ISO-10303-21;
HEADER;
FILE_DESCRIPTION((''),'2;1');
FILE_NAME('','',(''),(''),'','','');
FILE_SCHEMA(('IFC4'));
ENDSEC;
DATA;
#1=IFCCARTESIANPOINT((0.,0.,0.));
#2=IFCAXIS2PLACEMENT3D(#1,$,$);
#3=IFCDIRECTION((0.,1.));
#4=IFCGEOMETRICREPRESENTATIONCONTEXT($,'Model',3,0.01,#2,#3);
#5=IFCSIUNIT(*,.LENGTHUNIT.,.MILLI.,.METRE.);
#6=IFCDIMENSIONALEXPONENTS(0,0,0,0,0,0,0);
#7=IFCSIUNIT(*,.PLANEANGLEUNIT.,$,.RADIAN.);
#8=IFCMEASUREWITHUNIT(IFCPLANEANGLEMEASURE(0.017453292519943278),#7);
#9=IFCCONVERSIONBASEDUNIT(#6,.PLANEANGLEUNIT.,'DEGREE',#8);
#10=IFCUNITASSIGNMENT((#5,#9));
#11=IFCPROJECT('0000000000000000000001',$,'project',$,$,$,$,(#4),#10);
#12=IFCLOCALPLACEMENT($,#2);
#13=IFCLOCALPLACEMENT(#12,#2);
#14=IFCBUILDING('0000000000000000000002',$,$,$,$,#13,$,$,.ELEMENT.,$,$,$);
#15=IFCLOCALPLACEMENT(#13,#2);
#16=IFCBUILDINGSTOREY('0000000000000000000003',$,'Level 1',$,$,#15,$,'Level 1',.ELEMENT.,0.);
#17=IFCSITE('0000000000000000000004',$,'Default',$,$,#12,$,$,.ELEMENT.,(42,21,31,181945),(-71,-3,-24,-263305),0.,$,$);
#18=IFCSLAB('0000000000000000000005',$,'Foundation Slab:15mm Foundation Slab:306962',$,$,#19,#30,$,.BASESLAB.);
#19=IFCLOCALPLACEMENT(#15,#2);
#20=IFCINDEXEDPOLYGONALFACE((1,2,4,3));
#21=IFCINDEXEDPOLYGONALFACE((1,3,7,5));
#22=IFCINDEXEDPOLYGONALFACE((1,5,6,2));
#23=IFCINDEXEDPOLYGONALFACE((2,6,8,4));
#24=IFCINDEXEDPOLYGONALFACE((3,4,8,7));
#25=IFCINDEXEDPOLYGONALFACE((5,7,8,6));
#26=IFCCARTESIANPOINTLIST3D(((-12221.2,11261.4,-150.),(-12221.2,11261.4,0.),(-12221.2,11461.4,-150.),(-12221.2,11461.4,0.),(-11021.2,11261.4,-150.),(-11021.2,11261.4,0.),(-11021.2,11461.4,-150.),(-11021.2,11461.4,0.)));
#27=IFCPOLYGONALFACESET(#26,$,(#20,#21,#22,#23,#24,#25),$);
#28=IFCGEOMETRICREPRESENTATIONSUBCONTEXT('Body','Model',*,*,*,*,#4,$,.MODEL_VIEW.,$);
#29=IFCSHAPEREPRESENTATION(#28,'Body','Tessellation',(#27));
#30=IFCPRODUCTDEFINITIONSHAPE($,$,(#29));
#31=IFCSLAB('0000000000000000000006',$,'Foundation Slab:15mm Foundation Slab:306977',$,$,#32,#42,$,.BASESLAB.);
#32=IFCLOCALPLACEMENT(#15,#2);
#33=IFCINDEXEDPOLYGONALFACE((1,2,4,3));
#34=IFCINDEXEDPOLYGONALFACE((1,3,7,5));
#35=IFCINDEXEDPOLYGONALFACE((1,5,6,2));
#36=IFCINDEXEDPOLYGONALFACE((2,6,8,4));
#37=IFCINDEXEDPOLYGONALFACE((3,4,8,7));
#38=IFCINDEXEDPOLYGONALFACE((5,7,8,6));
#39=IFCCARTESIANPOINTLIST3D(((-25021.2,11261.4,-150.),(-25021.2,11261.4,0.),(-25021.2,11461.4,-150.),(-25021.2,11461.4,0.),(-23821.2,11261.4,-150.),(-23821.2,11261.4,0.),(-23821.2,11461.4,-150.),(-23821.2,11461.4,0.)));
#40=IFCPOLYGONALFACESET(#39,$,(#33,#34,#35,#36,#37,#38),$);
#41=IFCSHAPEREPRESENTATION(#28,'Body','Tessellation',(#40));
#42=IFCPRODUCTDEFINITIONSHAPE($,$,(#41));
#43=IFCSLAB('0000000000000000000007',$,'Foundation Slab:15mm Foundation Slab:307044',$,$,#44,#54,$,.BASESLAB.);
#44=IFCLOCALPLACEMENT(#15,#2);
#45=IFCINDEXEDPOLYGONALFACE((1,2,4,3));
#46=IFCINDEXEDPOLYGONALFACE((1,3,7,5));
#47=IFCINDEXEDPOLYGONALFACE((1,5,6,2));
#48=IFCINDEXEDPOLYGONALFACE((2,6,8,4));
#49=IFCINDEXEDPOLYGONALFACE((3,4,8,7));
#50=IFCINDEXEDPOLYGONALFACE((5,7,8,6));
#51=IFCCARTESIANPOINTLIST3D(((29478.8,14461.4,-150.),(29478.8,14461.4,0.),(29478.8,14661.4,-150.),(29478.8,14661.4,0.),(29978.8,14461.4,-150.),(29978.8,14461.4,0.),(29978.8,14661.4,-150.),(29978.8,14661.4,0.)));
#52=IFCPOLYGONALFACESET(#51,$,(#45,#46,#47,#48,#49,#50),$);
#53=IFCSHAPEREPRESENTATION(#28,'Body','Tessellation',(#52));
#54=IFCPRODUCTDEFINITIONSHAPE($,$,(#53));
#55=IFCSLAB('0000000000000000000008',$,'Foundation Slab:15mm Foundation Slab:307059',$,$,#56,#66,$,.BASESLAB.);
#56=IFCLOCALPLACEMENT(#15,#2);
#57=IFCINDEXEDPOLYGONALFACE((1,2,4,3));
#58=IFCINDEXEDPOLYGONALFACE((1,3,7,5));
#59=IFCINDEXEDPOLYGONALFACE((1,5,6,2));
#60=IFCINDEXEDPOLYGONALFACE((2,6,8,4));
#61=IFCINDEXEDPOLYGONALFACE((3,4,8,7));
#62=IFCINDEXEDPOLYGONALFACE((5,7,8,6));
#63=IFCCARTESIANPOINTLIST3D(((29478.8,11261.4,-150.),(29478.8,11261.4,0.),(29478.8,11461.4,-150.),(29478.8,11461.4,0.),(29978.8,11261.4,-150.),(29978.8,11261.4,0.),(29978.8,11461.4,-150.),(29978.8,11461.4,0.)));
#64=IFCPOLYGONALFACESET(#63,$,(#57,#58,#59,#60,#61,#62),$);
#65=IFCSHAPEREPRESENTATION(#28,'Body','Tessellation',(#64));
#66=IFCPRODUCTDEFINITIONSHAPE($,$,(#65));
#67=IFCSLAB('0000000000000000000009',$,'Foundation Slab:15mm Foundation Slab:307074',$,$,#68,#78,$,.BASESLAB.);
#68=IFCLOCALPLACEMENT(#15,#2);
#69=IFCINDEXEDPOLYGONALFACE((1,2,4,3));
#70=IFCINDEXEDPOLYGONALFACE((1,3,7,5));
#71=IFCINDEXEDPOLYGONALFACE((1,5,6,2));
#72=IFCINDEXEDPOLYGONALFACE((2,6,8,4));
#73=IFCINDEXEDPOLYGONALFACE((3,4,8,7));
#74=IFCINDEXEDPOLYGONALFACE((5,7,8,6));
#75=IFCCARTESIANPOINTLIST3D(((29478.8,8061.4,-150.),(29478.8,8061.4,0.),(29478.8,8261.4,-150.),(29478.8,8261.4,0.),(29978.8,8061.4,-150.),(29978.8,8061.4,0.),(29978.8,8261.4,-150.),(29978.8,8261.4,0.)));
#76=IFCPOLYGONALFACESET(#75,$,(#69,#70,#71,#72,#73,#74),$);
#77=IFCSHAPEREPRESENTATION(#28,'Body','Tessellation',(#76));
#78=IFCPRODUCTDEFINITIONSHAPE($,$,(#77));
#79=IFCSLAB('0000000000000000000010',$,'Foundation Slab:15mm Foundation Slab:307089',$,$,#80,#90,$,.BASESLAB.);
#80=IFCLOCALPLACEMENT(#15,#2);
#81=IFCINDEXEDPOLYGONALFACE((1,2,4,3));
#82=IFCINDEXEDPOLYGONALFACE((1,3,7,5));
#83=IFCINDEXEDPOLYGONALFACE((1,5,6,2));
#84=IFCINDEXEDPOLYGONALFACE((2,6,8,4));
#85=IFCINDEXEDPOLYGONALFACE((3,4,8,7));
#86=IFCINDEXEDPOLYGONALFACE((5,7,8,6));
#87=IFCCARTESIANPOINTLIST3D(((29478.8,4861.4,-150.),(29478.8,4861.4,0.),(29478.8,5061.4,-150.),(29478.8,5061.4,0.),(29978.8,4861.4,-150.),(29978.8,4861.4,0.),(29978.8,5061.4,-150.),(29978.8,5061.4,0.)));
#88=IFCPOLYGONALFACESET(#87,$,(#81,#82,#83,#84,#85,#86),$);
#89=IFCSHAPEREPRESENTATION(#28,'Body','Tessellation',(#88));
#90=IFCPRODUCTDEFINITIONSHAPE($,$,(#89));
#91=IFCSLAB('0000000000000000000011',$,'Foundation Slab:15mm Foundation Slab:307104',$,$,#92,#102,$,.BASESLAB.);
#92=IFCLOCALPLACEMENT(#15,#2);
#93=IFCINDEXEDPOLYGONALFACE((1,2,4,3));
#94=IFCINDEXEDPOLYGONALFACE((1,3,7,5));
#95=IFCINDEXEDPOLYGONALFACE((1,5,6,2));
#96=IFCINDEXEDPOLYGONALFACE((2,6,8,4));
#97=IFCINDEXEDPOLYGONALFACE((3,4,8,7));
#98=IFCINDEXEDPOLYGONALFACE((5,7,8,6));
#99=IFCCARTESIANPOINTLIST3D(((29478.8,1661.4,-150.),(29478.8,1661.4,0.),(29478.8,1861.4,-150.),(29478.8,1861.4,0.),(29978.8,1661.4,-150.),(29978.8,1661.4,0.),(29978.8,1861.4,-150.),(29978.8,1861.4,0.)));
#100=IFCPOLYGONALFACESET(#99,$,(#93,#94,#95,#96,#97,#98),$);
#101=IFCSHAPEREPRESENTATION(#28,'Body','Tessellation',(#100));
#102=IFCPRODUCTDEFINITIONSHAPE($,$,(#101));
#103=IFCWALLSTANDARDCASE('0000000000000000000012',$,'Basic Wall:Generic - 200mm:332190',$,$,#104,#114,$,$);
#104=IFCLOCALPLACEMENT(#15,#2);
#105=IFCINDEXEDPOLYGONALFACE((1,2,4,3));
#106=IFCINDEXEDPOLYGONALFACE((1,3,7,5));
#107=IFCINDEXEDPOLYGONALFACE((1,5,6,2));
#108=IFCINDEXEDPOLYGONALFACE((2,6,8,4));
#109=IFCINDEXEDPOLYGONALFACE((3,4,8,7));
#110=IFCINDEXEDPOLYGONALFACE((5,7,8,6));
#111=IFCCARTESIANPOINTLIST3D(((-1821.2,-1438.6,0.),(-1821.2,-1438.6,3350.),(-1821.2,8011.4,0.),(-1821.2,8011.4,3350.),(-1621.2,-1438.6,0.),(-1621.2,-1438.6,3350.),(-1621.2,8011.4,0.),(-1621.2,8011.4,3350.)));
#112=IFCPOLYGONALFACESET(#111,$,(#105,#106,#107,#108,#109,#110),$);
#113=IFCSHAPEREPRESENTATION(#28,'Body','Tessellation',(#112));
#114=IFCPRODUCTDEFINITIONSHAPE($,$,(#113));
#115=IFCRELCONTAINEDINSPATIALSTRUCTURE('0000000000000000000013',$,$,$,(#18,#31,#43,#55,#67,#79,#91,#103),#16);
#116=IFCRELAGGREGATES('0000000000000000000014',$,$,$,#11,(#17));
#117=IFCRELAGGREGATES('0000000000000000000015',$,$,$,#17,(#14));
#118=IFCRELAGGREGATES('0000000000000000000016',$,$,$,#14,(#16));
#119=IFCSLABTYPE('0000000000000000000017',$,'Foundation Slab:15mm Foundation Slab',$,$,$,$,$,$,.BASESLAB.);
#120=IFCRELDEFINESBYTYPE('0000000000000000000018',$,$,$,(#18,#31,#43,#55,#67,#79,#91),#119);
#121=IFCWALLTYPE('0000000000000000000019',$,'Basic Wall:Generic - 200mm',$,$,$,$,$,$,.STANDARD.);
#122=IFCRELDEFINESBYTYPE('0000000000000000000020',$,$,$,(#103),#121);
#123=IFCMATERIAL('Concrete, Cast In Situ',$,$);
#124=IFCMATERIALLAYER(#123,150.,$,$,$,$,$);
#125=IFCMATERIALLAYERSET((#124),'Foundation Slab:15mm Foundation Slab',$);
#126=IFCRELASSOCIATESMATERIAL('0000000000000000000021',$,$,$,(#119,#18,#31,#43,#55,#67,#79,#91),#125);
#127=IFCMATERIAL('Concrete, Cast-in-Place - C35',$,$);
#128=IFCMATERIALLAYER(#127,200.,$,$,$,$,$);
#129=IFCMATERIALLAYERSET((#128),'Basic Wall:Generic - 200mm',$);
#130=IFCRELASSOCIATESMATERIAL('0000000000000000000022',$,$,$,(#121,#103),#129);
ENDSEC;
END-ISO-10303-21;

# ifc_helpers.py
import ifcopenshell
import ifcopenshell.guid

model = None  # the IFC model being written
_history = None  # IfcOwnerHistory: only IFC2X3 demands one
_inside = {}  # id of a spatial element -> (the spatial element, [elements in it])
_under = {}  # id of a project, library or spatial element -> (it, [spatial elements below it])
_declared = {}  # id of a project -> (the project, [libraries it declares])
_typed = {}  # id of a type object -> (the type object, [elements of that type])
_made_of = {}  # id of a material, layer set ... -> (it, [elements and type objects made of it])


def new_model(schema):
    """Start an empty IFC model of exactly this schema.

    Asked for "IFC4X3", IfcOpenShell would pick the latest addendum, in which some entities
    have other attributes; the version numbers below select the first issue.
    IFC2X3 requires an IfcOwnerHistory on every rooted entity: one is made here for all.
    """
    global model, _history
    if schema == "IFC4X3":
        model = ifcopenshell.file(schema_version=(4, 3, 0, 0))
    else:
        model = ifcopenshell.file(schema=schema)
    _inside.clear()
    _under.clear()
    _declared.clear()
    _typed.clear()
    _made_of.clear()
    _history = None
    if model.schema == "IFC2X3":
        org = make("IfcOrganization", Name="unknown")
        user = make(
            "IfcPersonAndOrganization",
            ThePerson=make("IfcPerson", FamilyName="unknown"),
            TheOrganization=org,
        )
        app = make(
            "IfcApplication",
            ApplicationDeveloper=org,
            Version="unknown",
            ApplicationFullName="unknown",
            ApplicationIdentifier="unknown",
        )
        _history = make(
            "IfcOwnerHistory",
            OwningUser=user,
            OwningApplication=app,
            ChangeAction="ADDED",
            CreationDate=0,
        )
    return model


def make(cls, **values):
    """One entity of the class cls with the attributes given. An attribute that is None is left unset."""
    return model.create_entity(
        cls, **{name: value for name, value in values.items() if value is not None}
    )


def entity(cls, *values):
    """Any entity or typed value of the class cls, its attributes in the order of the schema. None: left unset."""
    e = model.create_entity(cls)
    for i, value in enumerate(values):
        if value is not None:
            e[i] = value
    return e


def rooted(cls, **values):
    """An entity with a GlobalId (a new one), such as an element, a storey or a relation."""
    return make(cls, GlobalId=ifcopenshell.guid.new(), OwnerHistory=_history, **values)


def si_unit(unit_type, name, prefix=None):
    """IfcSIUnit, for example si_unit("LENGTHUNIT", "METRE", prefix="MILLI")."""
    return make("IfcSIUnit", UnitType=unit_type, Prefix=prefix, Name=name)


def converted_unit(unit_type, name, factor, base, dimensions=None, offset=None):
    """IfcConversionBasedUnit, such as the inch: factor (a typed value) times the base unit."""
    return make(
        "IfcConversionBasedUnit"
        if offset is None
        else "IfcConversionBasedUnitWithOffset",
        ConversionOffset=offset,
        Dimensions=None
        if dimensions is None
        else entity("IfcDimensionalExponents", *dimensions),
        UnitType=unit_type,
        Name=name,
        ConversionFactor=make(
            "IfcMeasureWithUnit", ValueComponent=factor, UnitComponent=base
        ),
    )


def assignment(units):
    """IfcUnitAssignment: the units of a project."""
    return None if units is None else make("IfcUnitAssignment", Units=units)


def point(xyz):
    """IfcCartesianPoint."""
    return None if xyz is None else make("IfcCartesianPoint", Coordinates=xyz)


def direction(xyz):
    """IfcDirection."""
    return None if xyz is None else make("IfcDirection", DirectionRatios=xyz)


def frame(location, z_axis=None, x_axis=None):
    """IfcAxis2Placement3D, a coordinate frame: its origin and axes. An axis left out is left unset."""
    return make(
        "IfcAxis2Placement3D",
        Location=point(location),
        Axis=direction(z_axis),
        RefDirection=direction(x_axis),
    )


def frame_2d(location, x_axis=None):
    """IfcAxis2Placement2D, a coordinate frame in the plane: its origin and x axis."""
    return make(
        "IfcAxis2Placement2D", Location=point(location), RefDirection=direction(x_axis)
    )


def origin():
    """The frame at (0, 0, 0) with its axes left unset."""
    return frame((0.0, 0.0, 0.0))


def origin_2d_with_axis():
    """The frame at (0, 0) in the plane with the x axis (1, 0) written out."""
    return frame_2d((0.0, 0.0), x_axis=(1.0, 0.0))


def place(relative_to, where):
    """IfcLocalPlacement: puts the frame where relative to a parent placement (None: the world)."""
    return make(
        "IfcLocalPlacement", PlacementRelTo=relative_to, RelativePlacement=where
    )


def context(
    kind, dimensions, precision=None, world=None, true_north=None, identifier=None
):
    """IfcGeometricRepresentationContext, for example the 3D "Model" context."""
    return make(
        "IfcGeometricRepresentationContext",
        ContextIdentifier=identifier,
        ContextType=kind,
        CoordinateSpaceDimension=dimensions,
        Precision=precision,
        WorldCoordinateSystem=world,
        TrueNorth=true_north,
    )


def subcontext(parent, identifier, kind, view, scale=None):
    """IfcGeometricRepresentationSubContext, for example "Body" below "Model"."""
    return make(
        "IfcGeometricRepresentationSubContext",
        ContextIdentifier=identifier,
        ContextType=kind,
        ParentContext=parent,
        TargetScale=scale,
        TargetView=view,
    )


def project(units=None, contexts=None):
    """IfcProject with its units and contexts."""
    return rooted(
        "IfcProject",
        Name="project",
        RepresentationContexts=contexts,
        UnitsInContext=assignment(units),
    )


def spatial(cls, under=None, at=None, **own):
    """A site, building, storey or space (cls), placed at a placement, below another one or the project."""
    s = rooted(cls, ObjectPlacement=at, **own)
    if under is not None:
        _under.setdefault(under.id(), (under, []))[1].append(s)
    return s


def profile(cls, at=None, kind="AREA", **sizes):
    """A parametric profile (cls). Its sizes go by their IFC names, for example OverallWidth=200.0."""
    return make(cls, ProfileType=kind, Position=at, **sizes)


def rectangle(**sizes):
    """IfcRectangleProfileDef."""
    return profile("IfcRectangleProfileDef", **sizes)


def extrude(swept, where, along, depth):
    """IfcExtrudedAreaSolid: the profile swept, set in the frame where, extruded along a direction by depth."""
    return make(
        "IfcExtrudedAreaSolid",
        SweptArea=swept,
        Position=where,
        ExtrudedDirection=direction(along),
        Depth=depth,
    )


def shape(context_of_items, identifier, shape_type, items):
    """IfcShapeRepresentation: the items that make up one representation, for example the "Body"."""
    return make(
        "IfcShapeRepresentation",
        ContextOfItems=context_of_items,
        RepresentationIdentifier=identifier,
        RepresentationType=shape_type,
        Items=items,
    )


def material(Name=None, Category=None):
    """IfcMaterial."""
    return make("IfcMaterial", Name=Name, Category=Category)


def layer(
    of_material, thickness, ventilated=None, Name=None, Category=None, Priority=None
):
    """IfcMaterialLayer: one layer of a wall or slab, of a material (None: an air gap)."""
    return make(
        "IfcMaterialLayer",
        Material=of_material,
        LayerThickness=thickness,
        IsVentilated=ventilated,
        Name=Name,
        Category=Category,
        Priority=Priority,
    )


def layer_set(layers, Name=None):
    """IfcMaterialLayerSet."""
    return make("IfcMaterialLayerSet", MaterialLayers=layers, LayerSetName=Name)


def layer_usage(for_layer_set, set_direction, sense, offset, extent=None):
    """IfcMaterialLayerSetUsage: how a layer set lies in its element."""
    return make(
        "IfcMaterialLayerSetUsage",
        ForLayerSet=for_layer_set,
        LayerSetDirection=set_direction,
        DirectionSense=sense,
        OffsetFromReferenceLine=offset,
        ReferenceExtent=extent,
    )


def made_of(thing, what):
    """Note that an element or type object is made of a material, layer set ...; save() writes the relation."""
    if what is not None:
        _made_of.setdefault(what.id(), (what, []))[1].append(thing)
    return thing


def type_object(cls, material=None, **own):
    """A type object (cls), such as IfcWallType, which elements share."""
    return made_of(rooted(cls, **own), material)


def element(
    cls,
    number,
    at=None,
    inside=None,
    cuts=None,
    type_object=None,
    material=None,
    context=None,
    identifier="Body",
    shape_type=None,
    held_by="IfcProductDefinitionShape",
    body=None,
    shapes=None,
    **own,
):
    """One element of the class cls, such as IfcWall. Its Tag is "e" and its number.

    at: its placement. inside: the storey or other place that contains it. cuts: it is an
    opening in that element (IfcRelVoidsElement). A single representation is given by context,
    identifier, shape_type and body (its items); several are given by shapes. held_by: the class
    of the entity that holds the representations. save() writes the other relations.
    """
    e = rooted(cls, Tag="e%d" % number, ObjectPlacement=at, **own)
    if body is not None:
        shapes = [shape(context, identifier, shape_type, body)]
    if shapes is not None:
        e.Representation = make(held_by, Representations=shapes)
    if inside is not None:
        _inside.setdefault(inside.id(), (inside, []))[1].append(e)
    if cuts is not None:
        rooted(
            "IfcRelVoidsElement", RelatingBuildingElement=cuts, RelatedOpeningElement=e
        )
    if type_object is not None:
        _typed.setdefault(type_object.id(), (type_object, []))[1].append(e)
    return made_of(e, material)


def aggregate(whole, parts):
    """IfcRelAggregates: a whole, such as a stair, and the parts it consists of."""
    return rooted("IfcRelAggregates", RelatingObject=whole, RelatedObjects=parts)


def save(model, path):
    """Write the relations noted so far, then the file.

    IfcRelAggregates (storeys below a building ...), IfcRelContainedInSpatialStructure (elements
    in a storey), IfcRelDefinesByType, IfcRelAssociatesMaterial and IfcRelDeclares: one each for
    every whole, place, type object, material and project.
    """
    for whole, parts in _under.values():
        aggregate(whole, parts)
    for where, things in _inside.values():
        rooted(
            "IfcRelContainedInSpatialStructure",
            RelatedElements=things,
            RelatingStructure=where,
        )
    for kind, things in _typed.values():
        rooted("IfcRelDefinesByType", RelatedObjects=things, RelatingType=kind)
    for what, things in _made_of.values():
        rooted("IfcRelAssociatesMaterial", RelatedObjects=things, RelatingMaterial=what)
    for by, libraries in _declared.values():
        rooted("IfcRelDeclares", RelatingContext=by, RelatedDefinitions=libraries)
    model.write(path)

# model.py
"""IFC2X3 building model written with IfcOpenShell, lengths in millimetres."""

from ifc_helpers import new_model, entity, si_unit, converted_unit, direction, frame, frame_2d, origin, origin_2d_with_axis, place, context, subcontext, project, spatial, rectangle, extrude, material, layer, layer_set, layer_usage, type_object, element, save


model = new_model("IFC2X3")

# Units and contexts
model_context = context("Model", 3, precision=0.01, world=origin(), true_north=direction((0.0, 1.0)))
body_context = subcontext(model_context, "Body", "Model", "MODEL_VIEW")
ifc_project = project(units=[si_unit("LENGTHUNIT", "METRE", prefix="MILLI"), converted_unit("PLANEANGLEUNIT", "DEGREE", entity("IfcPlaneAngleMeasure", 0.017453292519943278), si_unit("PLANEANGLEUNIT", "RADIAN"), dimensions=[0, 0, 0, 0, 0, 0, 0])], contexts=[model_context])

# Site, building, storey
site_placement = place(None, origin())
site = spatial("IfcSite", under=ifc_project, at=site_placement, Name="Default", CompositionType="ELEMENT", RefLatitude=(42, 21, 31, 181945), RefLongitude=(-71, -3, -24, -263305), RefElevation=0.0)
building_placement = place(site_placement, origin())
building = spatial("IfcBuilding", under=site, at=building_placement, CompositionType="ELEMENT")
storey_placement = place(building_placement, origin())
storey = spatial("IfcBuildingStorey", under=building, at=storey_placement, Name="Level 1", LongName="Level 1", CompositionType="ELEMENT", Elevation=0.0)

# Shared definitions
ifc_material_1 = material(Name="Concrete, Cast-in-Place - C35")

# Slabs
ifc_material_2 = material(Name="Concrete, Cast In Situ")
ifc_layer_1 = layer(ifc_material_2, 150.0)
ifc_layer_set_1 = layer_set([ifc_layer_1], Name="Foundation Slab:15mm Foundation Slab")
slab_type = type_object("IfcSlabType", Name="Foundation Slab:15mm Foundation Slab", PredefinedType="BASESLAB", material=ifc_layer_set_1)
ifc_layer_usage_1 = layer_usage(ifc_layer_set_1, "AXIS3", "POSITIVE", 0.0)
slab_1_placement = place(storey_placement, origin())
element("IfcSlab", 1, at=slab_1_placement, inside=storey, type_object=slab_type, material=ifc_layer_usage_1, Name="Foundation Slab:15mm Foundation Slab:306962", PredefinedType="BASESLAB", context=body_context, shape_type="SweptSolid", body=[
    extrude(rectangle(XDim=200.0, YDim=1200.0, at=frame_2d((0.0, 0.0), x_axis=(1.0, 0.0))), frame((-11621.2, 11361.4, 0.0), z_axis=(0.0, 0.0, -1.0), x_axis=(0.0, 1.0, 0.0)), (0.0, 0.0, 1.0), 150.0),
])
ifc_layer_usage_2 = layer_usage(ifc_layer_set_1, "AXIS3", "POSITIVE", 0.0)
slab_2_placement = place(storey_placement, origin())
element("IfcSlab", 2, at=slab_2_placement, inside=storey, type_object=slab_type, material=ifc_layer_usage_2, Name="Foundation Slab:15mm Foundation Slab:306977", PredefinedType="BASESLAB", context=body_context, shape_type="SweptSolid", body=[
    extrude(rectangle(XDim=200.0, YDim=1200.0, at=frame_2d((0.0, 0.0), x_axis=(1.0, 0.0))), frame((-24421.2, 11361.4, 0.0), z_axis=(0.0, 0.0, -1.0), x_axis=(0.0, 1.0, 0.0)), (0.0, 0.0, 1.0), 150.0),
])
ifc_layer_usage_3 = layer_usage(ifc_layer_set_1, "AXIS3", "POSITIVE", 0.0)
slab_3_placement = place(storey_placement, origin())
element("IfcSlab", 3, at=slab_3_placement, inside=storey, type_object=slab_type, material=ifc_layer_usage_3, Name="Foundation Slab:15mm Foundation Slab:307044", PredefinedType="BASESLAB", context=body_context, shape_type="SweptSolid", body=[
    extrude(rectangle(XDim=200.0, YDim=500.0, at=frame_2d((0.0, 0.0), x_axis=(1.0, 0.0))), frame((29728.8, 14561.4, 0.0), z_axis=(0.0, 0.0, -1.0), x_axis=(0.0, 1.0, 0.0)), (0.0, 0.0, 1.0), 150.0),
])
ifc_layer_usage_4 = layer_usage(ifc_layer_set_1, "AXIS3", "POSITIVE", 0.0)
slab_4_placement = place(storey_placement, origin())
element("IfcSlab", 4, at=slab_4_placement, inside=storey, type_object=slab_type, material=ifc_layer_usage_4, Name="Foundation Slab:15mm Foundation Slab:307059", PredefinedType="BASESLAB", context=body_context, shape_type="SweptSolid", body=[
    extrude(rectangle(XDim=200.0, YDim=500.0, at=frame_2d((0.0, 0.0), x_axis=(1.0, 0.0))), frame((29728.8, 11361.4, 0.0), z_axis=(0.0, 0.0, -1.0), x_axis=(0.0, 1.0, 0.0)), (0.0, 0.0, 1.0), 150.0),
])
ifc_layer_usage_5 = layer_usage(ifc_layer_set_1, "AXIS3", "POSITIVE", 0.0)
slab_5_placement = place(storey_placement, origin())
element("IfcSlab", 5, at=slab_5_placement, inside=storey, type_object=slab_type, material=ifc_layer_usage_5, Name="Foundation Slab:15mm Foundation Slab:307074", PredefinedType="BASESLAB", context=body_context, shape_type="SweptSolid", body=[
    extrude(rectangle(XDim=200.0, YDim=500.0, at=frame_2d((0.0, 0.0), x_axis=(1.0, 0.0))), frame((29728.8, 8161.4, 0.0), z_axis=(0.0, 0.0, -1.0), x_axis=(0.0, 1.0, 0.0)), (0.0, 0.0, 1.0), 150.0),
])
ifc_layer_usage_6 = layer_usage(ifc_layer_set_1, "AXIS3", "POSITIVE", 0.0)
slab_6_placement = place(storey_placement, origin())
element("IfcSlab", 6, at=slab_6_placement, inside=storey, type_object=slab_type, material=ifc_layer_usage_6, Name="Foundation Slab:15mm Foundation Slab:307089", PredefinedType="BASESLAB", context=body_context, shape_type="SweptSolid", body=[
    extrude(rectangle(XDim=200.0, YDim=500.0, at=origin_2d_with_axis()), frame((29728.8, 4961.4, 0.0), z_axis=(0.0, 0.0, -1.0), x_axis=(0.0, 1.0, 0.0)), (0.0, 0.0, 1.0), 150.0),
])
ifc_layer_usage_7 = layer_usage(ifc_layer_set_1, "AXIS3", "POSITIVE", 0.0)
slab_7_placement = place(storey_placement, origin())
element("IfcSlab", 7, at=slab_7_placement, inside=storey, type_object=slab_type, material=ifc_layer_usage_7, Name="Foundation Slab:15mm Foundation Slab:307104", PredefinedType="BASESLAB", context=body_context, shape_type="SweptSolid", body=[
    extrude(rectangle(XDim=200.0, YDim=500.0, at=origin_2d_with_axis()), frame((29728.8, 1761.4, 0.0), z_axis=(0.0, 0.0, -1.0), x_axis=(0.0, 1.0, 0.0)), (0.0, 0.0, 1.0), 150.0),
])

# Wall
ifc_layer_2 = layer(ifc_material_1, 200.0)
ifc_layer_set_2 = layer_set([ifc_layer_2], Name="Basic Wall:Generic - 200mm")
ifc_layer_usage_8 = layer_usage(ifc_layer_set_2, "AXIS2", "NEGATIVE", 100.0)
wall_type = type_object("IfcWallType", Name="Basic Wall:Generic - 200mm", PredefinedType="STANDARD", material=ifc_layer_set_2)
wall_placement = place(storey_placement, frame((-1721.2, 8011.4, 0.0), z_axis=(0.0, 0.0, 1.0), x_axis=(0.0, -1.0, 0.0)))
element("IfcWallStandardCase", 8, at=wall_placement, inside=storey, type_object=wall_type, material=ifc_layer_usage_8, Name="Basic Wall:Generic - 200mm:332190", context=body_context, shape_type="SweptSolid", body=[
    extrude(rectangle(XDim=9450.0, YDim=200.0, at=frame_2d((4725.0, 0.0), x_axis=(-1.0, 0.0))), origin(), (0.0, 0.0, 1.0), 3350.0),
])

save(model, "model.ifc")
